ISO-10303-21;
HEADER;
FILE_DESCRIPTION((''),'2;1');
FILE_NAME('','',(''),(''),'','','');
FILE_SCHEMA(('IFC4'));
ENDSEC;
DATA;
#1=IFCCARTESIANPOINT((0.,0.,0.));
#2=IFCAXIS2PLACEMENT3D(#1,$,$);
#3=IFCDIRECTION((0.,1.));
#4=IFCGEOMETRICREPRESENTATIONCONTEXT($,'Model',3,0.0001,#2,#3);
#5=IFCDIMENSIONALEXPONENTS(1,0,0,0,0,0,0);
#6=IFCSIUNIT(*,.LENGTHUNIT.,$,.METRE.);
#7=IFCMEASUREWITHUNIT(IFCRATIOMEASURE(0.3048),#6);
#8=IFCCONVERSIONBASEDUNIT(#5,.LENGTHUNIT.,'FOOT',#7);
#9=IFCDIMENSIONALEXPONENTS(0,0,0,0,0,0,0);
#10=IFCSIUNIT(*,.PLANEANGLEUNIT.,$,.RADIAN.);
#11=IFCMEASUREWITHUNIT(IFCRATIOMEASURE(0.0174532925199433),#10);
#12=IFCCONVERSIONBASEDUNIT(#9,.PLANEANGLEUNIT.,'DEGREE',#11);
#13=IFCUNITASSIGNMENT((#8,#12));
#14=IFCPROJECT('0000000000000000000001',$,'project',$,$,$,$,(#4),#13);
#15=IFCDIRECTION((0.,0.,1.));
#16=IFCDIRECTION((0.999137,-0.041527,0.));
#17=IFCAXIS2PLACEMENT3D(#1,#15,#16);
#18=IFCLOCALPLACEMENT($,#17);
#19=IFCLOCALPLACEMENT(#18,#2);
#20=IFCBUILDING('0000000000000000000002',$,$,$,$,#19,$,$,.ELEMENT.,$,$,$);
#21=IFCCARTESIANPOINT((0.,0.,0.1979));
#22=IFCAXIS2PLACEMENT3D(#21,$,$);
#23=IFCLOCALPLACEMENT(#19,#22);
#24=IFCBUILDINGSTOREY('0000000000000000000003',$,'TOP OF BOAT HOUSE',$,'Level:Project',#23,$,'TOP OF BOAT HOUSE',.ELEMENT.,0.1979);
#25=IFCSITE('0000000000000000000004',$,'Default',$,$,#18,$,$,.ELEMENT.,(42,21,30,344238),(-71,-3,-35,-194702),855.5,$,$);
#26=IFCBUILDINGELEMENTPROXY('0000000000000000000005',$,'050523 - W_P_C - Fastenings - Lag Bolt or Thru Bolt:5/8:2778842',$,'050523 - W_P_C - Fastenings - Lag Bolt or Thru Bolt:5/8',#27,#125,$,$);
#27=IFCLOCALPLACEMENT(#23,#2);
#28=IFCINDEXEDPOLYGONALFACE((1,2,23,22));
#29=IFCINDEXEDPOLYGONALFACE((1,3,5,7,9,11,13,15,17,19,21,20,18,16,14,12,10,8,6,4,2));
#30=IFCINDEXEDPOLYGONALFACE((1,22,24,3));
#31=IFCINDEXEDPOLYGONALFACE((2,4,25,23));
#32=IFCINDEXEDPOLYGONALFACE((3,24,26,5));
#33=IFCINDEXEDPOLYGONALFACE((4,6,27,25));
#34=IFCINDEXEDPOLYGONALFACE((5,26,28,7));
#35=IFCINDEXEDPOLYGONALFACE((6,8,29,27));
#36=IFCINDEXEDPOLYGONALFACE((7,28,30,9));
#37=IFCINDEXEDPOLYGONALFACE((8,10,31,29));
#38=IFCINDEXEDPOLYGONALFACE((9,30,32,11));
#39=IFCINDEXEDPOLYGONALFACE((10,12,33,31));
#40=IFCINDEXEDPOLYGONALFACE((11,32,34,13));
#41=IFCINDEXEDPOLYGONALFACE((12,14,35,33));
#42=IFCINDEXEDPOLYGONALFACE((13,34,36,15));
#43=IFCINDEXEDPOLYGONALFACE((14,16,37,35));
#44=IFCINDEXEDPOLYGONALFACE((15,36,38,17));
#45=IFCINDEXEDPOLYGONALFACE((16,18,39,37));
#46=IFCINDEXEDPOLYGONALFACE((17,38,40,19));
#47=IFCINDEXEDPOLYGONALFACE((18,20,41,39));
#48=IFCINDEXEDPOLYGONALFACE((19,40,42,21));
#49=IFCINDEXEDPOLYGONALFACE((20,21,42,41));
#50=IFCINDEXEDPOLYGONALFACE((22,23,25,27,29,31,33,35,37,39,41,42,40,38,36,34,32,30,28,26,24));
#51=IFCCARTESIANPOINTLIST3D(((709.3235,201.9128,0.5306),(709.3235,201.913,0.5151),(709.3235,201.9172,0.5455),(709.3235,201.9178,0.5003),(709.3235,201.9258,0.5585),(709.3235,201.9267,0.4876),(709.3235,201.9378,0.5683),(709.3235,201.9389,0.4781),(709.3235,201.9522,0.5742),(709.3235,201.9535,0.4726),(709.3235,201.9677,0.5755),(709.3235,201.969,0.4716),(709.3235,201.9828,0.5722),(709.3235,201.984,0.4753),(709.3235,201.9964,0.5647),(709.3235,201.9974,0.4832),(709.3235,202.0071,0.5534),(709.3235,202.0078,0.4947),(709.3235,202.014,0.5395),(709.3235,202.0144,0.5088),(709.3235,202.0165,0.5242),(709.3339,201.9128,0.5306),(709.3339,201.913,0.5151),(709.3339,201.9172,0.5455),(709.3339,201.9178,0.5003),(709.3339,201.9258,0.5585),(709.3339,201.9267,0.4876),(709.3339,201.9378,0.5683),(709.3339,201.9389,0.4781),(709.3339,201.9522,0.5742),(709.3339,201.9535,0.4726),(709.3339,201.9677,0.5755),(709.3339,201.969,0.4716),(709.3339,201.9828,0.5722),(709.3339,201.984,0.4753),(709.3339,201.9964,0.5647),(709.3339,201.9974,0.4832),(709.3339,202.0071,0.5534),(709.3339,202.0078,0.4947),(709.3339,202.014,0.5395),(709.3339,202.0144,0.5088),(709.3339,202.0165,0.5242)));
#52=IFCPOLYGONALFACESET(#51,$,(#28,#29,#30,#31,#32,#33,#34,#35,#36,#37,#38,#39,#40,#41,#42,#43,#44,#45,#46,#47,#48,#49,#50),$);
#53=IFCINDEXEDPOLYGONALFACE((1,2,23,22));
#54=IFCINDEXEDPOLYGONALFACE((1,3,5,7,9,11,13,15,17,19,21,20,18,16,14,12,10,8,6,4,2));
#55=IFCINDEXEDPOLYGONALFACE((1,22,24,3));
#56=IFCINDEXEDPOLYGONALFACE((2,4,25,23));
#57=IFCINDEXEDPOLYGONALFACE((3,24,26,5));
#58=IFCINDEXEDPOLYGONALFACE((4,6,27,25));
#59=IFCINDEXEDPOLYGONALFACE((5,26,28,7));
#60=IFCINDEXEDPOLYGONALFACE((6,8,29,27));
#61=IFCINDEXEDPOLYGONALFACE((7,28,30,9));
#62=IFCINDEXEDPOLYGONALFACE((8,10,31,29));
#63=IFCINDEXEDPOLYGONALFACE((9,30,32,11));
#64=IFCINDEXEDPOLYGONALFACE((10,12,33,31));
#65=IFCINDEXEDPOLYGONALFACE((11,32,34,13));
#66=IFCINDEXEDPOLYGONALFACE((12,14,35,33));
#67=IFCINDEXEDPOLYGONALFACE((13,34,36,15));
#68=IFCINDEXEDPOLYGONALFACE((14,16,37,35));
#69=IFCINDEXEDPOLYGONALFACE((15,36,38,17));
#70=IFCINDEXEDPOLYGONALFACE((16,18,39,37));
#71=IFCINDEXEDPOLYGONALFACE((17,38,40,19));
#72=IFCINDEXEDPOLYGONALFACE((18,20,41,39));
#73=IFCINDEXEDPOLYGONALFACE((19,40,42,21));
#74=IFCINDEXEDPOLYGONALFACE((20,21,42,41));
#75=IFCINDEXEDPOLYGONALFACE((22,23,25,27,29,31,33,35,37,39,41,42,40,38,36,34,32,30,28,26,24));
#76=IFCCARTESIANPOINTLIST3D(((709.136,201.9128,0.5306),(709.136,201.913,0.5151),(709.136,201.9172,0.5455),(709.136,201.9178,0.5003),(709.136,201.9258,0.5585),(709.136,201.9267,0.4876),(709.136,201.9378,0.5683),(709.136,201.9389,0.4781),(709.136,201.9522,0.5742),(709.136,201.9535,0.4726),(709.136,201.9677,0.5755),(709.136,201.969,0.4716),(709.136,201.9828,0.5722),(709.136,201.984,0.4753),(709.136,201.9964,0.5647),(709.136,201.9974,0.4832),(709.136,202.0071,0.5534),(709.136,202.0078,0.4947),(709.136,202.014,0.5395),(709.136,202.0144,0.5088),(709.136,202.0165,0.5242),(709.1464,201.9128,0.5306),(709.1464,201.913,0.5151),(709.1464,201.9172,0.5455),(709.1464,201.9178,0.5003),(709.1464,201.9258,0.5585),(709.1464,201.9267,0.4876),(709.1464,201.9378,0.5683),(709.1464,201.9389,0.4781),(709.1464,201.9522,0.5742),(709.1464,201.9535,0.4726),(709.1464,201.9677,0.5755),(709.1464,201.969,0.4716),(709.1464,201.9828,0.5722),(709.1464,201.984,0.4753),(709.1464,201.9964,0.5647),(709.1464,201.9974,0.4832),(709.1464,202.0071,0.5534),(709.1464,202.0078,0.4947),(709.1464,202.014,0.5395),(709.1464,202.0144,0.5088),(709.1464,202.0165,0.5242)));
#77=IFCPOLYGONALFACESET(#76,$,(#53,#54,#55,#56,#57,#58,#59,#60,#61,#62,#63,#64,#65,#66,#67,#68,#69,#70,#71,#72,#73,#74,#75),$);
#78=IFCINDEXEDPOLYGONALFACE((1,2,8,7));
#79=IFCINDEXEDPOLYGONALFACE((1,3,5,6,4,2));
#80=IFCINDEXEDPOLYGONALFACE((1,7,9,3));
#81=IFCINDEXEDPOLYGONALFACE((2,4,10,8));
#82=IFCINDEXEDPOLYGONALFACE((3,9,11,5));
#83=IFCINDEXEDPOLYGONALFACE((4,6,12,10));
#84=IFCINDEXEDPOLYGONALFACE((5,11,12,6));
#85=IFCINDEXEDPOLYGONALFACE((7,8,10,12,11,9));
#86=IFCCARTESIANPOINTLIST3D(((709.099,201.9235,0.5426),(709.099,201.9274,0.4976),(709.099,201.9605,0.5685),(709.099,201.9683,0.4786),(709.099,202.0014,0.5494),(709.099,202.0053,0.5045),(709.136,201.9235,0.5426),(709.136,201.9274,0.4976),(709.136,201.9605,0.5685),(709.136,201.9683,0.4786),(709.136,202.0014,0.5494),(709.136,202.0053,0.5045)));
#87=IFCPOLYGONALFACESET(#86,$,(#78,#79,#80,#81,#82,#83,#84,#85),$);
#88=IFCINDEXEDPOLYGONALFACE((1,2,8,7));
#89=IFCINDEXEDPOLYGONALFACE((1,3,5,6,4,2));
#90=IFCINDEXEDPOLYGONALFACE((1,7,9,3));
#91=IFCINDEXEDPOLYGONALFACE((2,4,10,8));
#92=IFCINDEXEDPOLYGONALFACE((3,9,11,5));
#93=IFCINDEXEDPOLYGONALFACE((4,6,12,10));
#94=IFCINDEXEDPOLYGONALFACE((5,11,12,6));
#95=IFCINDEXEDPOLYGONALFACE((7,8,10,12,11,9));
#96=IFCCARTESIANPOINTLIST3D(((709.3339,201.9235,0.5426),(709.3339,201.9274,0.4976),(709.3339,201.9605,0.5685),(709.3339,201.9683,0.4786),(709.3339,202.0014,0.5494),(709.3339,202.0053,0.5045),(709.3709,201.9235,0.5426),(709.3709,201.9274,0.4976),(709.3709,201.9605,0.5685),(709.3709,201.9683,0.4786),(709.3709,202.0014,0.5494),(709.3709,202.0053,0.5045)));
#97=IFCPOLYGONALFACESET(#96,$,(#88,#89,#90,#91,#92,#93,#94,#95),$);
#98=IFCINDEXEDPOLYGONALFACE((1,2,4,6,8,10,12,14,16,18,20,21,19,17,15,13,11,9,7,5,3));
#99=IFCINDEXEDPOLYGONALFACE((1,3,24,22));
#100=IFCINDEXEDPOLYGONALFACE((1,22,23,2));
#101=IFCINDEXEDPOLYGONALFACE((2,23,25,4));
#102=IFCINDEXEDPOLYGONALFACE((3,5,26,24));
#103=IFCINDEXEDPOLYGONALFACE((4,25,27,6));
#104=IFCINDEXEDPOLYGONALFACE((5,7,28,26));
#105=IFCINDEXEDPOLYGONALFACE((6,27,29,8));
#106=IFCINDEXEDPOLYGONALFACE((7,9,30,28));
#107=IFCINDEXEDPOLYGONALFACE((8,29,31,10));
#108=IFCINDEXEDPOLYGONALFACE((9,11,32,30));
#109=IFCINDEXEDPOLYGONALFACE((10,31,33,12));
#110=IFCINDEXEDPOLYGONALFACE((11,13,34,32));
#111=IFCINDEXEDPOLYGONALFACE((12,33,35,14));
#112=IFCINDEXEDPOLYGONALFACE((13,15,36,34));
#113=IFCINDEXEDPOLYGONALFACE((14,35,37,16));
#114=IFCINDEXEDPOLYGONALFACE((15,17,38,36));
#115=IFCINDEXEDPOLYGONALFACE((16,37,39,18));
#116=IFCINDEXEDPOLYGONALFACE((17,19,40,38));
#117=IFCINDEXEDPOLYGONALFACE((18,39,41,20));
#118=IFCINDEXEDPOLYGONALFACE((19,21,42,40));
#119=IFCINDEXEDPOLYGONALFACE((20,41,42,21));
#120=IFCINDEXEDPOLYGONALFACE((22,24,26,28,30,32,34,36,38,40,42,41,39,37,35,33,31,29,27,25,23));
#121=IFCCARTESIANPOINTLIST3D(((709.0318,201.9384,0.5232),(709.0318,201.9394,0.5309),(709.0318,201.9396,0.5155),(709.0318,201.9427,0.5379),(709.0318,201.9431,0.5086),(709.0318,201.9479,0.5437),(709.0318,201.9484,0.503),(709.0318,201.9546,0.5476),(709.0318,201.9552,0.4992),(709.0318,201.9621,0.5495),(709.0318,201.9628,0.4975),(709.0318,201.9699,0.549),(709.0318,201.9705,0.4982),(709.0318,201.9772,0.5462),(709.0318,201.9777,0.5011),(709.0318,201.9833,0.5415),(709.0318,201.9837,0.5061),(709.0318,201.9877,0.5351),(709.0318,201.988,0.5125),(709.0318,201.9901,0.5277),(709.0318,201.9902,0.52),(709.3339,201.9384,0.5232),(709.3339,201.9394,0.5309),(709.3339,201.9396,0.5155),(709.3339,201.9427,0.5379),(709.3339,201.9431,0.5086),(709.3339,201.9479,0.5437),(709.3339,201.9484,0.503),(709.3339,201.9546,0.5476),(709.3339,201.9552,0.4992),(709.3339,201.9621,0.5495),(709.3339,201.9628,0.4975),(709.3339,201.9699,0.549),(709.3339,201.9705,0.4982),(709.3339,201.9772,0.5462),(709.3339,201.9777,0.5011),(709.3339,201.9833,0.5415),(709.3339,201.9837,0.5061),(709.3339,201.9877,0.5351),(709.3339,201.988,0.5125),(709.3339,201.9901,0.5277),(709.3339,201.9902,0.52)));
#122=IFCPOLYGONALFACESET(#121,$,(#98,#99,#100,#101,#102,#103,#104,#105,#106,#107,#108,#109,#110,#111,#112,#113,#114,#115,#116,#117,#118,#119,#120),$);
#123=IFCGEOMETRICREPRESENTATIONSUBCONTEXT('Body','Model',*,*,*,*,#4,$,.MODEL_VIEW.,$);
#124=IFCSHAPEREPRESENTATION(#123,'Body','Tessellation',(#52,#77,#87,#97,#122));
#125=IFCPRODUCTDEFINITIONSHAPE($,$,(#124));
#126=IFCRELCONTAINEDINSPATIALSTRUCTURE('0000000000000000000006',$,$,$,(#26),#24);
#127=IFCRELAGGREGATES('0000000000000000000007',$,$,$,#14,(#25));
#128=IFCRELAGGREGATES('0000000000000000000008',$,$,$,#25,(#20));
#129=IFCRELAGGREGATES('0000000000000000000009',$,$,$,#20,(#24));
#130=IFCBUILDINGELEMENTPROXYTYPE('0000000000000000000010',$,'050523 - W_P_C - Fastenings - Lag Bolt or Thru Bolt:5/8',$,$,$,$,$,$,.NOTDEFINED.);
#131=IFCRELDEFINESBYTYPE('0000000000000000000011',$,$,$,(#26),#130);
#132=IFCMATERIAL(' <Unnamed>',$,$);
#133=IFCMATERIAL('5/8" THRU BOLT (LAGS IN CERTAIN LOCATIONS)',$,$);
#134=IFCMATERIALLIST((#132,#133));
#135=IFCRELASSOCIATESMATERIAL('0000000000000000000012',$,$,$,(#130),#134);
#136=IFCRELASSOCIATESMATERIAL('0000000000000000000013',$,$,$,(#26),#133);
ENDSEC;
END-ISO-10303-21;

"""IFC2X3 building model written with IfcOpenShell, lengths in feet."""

from ifc_helpers import new_model, entity, si_unit, converted_unit, direction, frame, frame_2d, origin, place, context, subcontext, project, spatial, polyline, circle, outline, extrude, source, transform, mapped, material, material_list, type_object, type_shapes, element, save


model = new_model("IFC2X3")

# Units and contexts
model_context = context("Model", 3, precision=0.0001, world=origin(), true_north=direction((0.0, 1.0)))
body_context = subcontext(model_context, "Body", "Model", "MODEL_VIEW")
ifc_project = project(units=[converted_unit("LENGTHUNIT", "FOOT", entity("IfcRatioMeasure", 0.3048), si_unit("LENGTHUNIT", "METRE"), dimensions=[1, 0, 0, 0, 0, 0, 0]), converted_unit("PLANEANGLEUNIT", "DEGREE", entity("IfcRatioMeasure", 0.0174532925199433), si_unit("PLANEANGLEUNIT", "RADIAN"), dimensions=[0, 0, 0, 0, 0, 0, 0])], contexts=[model_context])

# Site, building, storey
site_placement = place(None, frame((0.0, 0.0, 0.0), z_axis=(0.0, 0.0, 1.0), x_axis=(0.999137, -0.041527, 0.0)))
site = spatial("IfcSite", under=ifc_project, at=site_placement, Name="Default", CompositionType="ELEMENT", RefLatitude=(42, 21, 30, 344238), RefLongitude=(-71, -3, -35, -194702), RefElevation=855.5)
building_placement = place(site_placement, origin())
building = spatial("IfcBuilding", under=site, at=building_placement, CompositionType="ELEMENT")
storey_placement = place(building_placement, frame((0.0, 0.0, 0.1979)))
storey = spatial("IfcBuildingStorey", under=building, at=storey_placement, Name="TOP OF BOAT HOUSE", ObjectType="Level:Project", LongName="TOP OF BOAT HOUSE", CompositionType="ELEMENT", Elevation=0.1979)

# Building element proxy
ifc_material_1 = material(Name="5/8\" THRU BOLT (LAGS IN CERTAIN LOCATIONS)")
ifc_material_2 = material(Name=" <Unnamed>")
ifc_material_list_1 = material_list([ifc_material_2, ifc_material_1])
building_element_proxy_type_1 = type_object("IfcBuildingElementProxyType", Name="050523 - W_P_C - Fastenings - Lag Bolt or Thru Bolt:5/8", PredefinedType="NOTDEFINED", material=ifc_material_list_1)
shared_shape_1 = source(origin(), body_context, "Body", "SweptSolid", [
    extrude(circle(Radius=0.0521, at=frame_2d((0.0, 0.0), x_axis=(1.0, 0.0))), frame((0.0, 0.0, 0.0), z_axis=(0.0, 0.0, 1.0), x_axis=(0.0, 1.0, 0.0)), (0.0, 0.0, 1.0), 0.0104),
    extrude(circle(Radius=0.0521, at=frame_2d((0.0, 0.0), x_axis=(1.0, 0.0))), frame((0.0, 0.0, -0.1875), z_axis=(0.0, 0.0, 1.0), x_axis=(0.0, 1.0, 0.0)), (0.0, 0.0, 1.0), 0.0104),
    extrude(outline(polyline([(-0.0226, -0.0391), (0.0226, -0.0391), (0.0451, 0.0), (0.0226, 0.0391), (-0.0226, 0.0391), (-0.0451, 0.0), (-0.0226, -0.0391)])), frame((0.0, 0.0, -0.2245), z_axis=(0.0, 0.0, 1.0), x_axis=(0.0, -1.0, 0.0)), (0.0, 0.0, 1.0), 0.037),
    extrude(outline(polyline([(-0.0226, -0.0391), (0.0226, -0.0391), (0.0451, 0.0), (0.0226, 0.0391), (-0.0226, 0.0391), (-0.0451, 0.0), (-0.0226, -0.0391)])), frame((0.0, 0.0, 0.0104), z_axis=(0.0, 0.0, 1.0), x_axis=(0.866025, -0.5, 0.0)), (0.0, 0.0, 1.0), 0.037),
    extrude(circle(Radius=0.026, at=frame_2d((0.0, 0.0), x_axis=(1.0, 0.0))), frame((0.0, 0.0, -0.2917), z_axis=(0.0, 0.0, 1.0), x_axis=(0.0, -1.0, 0.0)), (0.0, 0.0, 1.0), 0.3021),
])
type_shapes(building_element_proxy_type_1, [shared_shape_1])
for number, where, z_axis, x_axis, name in (
    (1, (709.3235, 201.9644, 0.5235), (1.0, 0.0, 0.0), (0.0, -0.996195, -0.087156), "050523 - W_P_C - Fastenings - Lag Bolt or Thru Bolt:5/8:2778842"),
):
    element("IfcBuildingElementProxy", number, at=place(storey_placement, frame(where, z_axis=z_axis, x_axis=x_axis)), inside=storey, type_object=building_element_proxy_type_1, material=ifc_material_1, Name=name, ObjectType="050523 - W_P_C - Fastenings - Lag Bolt or Thru Bolt:5/8", context=body_context, shape_type="MappedRepresentation", body=[
        mapped(shared_shape_1, transform((0.0, 0.0, 0.0), scale=1.0)),
    ])

save(model, "model.ifc")
